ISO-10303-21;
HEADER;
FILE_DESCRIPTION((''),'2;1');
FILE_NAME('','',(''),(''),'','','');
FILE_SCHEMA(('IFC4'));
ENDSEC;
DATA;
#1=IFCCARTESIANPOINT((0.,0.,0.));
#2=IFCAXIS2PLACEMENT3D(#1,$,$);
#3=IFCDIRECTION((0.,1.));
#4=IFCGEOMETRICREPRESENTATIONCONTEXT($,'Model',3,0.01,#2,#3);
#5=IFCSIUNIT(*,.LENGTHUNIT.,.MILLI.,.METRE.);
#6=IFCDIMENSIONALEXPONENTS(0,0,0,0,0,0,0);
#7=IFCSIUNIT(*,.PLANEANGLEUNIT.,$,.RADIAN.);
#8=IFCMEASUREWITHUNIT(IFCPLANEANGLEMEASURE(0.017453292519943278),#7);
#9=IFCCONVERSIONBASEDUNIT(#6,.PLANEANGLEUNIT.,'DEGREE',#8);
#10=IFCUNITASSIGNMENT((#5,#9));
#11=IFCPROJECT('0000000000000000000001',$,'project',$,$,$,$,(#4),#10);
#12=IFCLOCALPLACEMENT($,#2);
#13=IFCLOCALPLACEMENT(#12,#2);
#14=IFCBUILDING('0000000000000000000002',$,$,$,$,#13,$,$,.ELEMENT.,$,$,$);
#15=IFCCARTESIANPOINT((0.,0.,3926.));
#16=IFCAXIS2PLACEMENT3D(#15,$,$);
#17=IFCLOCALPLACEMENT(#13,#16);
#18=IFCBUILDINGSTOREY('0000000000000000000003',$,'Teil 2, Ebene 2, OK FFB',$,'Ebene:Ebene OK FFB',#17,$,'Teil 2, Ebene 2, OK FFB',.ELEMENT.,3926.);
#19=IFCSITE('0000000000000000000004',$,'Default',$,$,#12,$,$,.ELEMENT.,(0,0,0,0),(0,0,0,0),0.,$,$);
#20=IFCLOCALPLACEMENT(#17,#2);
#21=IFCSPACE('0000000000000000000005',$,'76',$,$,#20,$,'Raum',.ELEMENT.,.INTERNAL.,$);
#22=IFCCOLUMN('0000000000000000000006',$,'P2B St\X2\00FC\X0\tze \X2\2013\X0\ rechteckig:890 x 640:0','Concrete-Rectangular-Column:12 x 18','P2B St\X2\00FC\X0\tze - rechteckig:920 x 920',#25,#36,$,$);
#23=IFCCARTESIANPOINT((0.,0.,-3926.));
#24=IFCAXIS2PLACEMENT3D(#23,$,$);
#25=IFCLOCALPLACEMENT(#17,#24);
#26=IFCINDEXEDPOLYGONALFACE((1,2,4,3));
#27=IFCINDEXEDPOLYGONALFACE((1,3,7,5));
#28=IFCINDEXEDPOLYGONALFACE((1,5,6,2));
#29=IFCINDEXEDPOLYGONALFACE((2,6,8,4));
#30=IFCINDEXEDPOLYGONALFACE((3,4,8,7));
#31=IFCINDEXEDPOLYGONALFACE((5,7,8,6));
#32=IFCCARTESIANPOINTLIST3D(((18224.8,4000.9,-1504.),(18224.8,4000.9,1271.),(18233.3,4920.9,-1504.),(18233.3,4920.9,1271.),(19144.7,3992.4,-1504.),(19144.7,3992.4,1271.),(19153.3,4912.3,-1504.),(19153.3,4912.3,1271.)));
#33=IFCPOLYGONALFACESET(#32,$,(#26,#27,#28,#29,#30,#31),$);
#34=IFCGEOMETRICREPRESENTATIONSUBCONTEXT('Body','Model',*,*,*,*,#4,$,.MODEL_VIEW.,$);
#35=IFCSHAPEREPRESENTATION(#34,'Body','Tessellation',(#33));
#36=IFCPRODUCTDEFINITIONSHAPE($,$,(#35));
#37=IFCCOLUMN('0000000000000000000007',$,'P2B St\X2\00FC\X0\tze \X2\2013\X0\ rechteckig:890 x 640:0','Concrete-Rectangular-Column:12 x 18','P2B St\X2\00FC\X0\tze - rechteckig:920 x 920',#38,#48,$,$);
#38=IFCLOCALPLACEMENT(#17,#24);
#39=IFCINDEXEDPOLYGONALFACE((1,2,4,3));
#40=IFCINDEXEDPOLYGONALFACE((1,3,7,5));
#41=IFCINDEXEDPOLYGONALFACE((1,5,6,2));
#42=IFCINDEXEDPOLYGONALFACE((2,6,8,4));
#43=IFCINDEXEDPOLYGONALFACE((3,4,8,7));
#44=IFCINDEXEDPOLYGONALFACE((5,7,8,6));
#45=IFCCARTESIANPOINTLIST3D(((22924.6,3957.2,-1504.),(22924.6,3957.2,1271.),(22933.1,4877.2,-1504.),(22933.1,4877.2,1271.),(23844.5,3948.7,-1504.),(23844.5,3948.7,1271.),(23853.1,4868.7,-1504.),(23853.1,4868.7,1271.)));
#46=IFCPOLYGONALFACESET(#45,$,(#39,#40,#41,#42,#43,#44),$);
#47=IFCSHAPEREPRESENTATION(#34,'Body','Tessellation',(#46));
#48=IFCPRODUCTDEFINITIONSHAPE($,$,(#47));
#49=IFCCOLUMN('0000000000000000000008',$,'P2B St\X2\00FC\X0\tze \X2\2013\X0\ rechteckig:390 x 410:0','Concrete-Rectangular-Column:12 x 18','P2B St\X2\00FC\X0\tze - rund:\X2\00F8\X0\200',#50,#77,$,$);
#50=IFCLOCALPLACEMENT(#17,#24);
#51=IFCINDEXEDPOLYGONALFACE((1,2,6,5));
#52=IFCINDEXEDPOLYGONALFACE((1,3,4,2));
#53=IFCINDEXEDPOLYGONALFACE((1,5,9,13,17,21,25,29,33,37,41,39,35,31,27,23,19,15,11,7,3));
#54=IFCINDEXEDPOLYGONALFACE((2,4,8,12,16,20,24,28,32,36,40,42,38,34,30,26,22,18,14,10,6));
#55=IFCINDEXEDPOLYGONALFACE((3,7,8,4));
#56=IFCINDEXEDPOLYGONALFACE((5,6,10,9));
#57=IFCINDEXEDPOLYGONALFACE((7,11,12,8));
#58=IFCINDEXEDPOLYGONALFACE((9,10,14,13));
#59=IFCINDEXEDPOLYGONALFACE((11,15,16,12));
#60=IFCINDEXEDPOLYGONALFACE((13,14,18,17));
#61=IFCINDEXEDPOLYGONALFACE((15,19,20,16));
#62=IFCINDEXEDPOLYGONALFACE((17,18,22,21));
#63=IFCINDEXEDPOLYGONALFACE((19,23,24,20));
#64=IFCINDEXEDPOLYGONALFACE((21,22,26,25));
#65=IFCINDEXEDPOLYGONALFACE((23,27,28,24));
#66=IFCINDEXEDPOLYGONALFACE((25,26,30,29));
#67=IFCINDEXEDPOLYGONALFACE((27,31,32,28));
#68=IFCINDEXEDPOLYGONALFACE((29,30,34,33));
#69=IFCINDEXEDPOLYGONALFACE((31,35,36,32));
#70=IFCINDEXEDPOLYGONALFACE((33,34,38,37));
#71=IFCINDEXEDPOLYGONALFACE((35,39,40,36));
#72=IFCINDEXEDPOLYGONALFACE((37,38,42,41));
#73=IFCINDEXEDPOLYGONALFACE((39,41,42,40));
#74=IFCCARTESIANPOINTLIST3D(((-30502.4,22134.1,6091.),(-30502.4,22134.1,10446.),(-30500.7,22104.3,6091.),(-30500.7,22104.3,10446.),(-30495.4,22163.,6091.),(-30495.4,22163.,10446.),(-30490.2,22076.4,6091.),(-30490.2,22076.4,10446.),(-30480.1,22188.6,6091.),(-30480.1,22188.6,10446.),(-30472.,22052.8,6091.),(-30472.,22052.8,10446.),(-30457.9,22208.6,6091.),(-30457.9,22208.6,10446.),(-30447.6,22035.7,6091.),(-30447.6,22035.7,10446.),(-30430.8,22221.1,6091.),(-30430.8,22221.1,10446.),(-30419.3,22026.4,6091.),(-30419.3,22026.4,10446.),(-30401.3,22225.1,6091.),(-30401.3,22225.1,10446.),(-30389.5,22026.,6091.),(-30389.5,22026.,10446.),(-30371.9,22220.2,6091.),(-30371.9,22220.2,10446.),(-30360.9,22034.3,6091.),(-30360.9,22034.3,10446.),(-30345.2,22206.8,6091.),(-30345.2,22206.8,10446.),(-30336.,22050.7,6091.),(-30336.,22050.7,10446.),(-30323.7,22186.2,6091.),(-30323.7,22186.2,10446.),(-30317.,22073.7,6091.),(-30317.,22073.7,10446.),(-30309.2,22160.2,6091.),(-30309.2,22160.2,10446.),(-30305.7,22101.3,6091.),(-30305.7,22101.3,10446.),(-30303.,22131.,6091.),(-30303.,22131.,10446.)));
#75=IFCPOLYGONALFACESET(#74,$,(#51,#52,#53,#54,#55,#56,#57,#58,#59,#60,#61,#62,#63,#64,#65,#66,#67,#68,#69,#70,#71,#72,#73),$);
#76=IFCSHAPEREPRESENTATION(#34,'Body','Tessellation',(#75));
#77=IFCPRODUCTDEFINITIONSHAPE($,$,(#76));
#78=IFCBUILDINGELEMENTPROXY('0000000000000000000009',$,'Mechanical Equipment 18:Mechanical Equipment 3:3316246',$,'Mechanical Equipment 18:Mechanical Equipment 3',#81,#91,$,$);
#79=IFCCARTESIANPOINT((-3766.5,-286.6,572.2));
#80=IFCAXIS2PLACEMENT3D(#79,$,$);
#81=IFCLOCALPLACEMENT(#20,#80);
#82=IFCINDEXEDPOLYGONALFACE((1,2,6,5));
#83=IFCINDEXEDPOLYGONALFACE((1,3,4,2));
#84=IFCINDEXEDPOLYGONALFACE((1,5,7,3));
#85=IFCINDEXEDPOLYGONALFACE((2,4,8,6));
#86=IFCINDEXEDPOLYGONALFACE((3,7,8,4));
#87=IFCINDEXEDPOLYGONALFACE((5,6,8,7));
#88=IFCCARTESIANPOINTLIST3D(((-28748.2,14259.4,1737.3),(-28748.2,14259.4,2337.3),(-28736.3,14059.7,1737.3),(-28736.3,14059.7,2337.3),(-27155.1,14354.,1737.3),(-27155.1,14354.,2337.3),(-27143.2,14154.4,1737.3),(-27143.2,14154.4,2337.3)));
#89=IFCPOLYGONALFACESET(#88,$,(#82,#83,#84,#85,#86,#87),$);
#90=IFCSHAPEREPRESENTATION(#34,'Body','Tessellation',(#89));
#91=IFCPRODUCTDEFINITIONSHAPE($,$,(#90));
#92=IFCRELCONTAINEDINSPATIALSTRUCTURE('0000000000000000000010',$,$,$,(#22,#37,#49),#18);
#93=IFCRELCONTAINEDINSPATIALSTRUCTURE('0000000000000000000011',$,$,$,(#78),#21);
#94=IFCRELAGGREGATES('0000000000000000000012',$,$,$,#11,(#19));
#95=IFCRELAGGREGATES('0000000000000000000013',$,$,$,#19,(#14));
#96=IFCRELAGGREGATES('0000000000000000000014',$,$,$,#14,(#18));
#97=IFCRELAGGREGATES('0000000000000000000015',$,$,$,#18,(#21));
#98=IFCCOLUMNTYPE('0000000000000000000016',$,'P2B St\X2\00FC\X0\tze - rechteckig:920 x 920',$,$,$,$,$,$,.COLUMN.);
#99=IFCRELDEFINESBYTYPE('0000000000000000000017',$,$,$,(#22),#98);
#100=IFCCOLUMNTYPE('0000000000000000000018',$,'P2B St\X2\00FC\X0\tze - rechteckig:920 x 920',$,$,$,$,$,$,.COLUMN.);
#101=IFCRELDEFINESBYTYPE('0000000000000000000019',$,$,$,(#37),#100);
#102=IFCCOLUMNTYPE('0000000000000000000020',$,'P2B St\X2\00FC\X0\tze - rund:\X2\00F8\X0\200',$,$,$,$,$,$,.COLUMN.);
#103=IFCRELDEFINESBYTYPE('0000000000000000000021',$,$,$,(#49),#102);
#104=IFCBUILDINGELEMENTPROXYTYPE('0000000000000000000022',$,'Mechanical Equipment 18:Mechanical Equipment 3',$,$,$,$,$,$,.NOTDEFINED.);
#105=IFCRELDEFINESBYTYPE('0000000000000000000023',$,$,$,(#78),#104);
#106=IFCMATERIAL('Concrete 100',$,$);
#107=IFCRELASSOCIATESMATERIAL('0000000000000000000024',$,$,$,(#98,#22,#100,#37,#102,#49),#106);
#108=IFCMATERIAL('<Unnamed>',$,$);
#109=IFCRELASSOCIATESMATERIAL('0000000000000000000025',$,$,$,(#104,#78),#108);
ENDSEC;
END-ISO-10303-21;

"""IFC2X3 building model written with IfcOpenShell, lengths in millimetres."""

from ifc_helpers import new_model, entity, si_unit, converted_unit, direction, frame, frame_2d, origin, origin_2d_with_axis, place, context, subcontext, project, spatial, rectangle, circle, extrude, source, transform, mapped, material, type_object, type_shapes, element, save


model = new_model("IFC2X3")

# Units and contexts
model_context = context("Model", 3, precision=0.01, world=origin(), true_north=direction((0.0, 1.0)))
body_context = subcontext(model_context, "Body", "Model", "MODEL_VIEW")
ifc_project = project(units=[si_unit("LENGTHUNIT", "METRE", prefix="MILLI"), converted_unit("PLANEANGLEUNIT", "DEGREE", entity("IfcPlaneAngleMeasure", 0.017453292519943278), si_unit("PLANEANGLEUNIT", "RADIAN"), dimensions=[0, 0, 0, 0, 0, 0, 0])], contexts=[model_context])

# Site, building, storey
site_placement = place(None, origin())
site = spatial("IfcSite", under=ifc_project, at=site_placement, Name="Default", CompositionType="ELEMENT", RefLatitude=(0, 0, 0, 0), RefLongitude=(0, 0, 0, 0), RefElevation=0.0)
building_placement = place(site_placement, origin())
building = spatial("IfcBuilding", under=site, at=building_placement, CompositionType="ELEMENT")
storey_placement = place(building_placement, frame((0.0, 0.0, 3926.0)))
storey = spatial("IfcBuildingStorey", under=building, at=storey_placement, Name="Teil 2, Ebene 2, OK FFB", ObjectType="Ebene:Ebene OK FFB", LongName="Teil 2, Ebene 2, OK FFB", CompositionType="ELEMENT", Elevation=3926.0)

# Columns
ifc_material_1 = material(Name="Concrete 100")
column_type_1 = type_object("IfcColumnType", Name="P2B Stütze - rechteckig:920 x 920", PredefinedType="COLUMN", material=ifc_material_1)
shared_shape_1 = source(origin(), body_context, "Body", "SweptSolid", [
    extrude(rectangle(XDim=920.0, YDim=920.0, at=frame_2d((3.3, 0.0), x_axis=(1.0, 0.0))), frame((18689.0, 4453.3, -1504.0), z_axis=(0.0, 0.0, 1.0), x_axis=(0.00929, 0.999957, 0.0)), (0.0, 0.0, 1.0), 2775.0),
])
type_shapes(column_type_1, [shared_shape_1])
column_1_placement = place(storey_placement, frame((0.0, 0.0, -3926.0)))
element("IfcColumn", 1, at=column_1_placement, inside=storey, type_object=column_type_1, material=ifc_material_1, Name="P2B Stütze – rechteckig:890 x 640:0", Description="Concrete-Rectangular-Column:12 x 18", ObjectType="P2B Stütze - rechteckig:920 x 920", context=body_context, shape_type="MappedRepresentation", body=[
    mapped(shared_shape_1, transform((0.0, 0.0, 0.0), scale=1.0)),
])
column_type_2 = type_object("IfcColumnType", Name="P2B Stütze - rechteckig:920 x 920", PredefinedType="COLUMN", material=ifc_material_1)
shared_shape_2 = source(origin(), body_context, "Body", "SweptSolid", [
    extrude(rectangle(XDim=920.0, YDim=920.0, at=frame_2d((3.3, 0.0), x_axis=(1.0, 0.0))), frame((23388.8, 4409.6, -1504.0), z_axis=(0.0, 0.0, 1.0), x_axis=(0.00929, 0.999957, 0.0)), (0.0, 0.0, 1.0), 2775.0),
])
type_shapes(column_type_2, [shared_shape_2])
column_2_placement = place(storey_placement, frame((0.0, 0.0, -3926.0)))
element("IfcColumn", 2, at=column_2_placement, inside=storey, type_object=column_type_2, material=ifc_material_1, Name="P2B Stütze – rechteckig:890 x 640:0", Description="Concrete-Rectangular-Column:12 x 18", ObjectType="P2B Stütze - rechteckig:920 x 920", context=body_context, shape_type="MappedRepresentation", body=[
    mapped(shared_shape_2, transform((0.0, 0.0, 0.0), scale=1.0)),
])
column_type_3 = type_object("IfcColumnType", Name="P2B Stütze - rund:ø200", PredefinedType="COLUMN", material=ifc_material_1)
shared_shape_3 = source(origin(), body_context, "Body", "SweptSolid", [
    extrude(circle(Radius=100.0, at=origin_2d_with_axis()), frame((-30402.8, 22125.1, 6091.0), z_axis=(0.0, 0.0, 1.0), x_axis=(0.998239, 0.059319, 0.0)), (0.0, 0.0, 1.0), 4355.0),
])
type_shapes(column_type_3, [shared_shape_3])
column_3_placement = place(storey_placement, frame((0.0, 0.0, -3926.0)))
element("IfcColumn", 3, at=column_3_placement, inside=storey, type_object=column_type_3, material=ifc_material_1, Name="P2B Stütze – rechteckig:390 x 410:0", Description="Concrete-Rectangular-Column:12 x 18", ObjectType="P2B Stütze - rund:ø200", context=body_context, shape_type="MappedRepresentation", body=[
    mapped(shared_shape_3, transform((0.0, 0.0, 0.0), scale=1.0)),
])

# Shared definitions
space_placement = place(storey_placement, origin())
space = spatial("IfcSpace", under=storey, at=space_placement, Name="76", LongName="Raum", CompositionType="ELEMENT", InteriorOrExteriorSpace="INTERNAL")

# Building element proxy
ifc_material_2 = material(Name="<Unnamed>")
building_element_proxy_type = type_object("IfcBuildingElementProxyType", Name="Mechanical Equipment 18:Mechanical Equipment 3", PredefinedType="NOTDEFINED", material=ifc_material_2)
shared_shape_4 = source(origin(), body_context, "Body", "SweptSolid", [
    extrude(rectangle(XDim=200.0, YDim=1595.9, at=origin_2d_with_axis()), frame((-27945.7, 14206.9, 1737.3), z_axis=(0.0, 0.0, 1.0), x_axis=(0.059319, -0.998239, 0.0)), (0.0, 0.0, 1.0), 600.0),
])
type_shapes(building_element_proxy_type, [shared_shape_4])
proxy_placement = place(space_placement, frame((-3766.5, -286.6, 572.2)))
element("IfcBuildingElementProxy", 4, at=proxy_placement, inside=space, type_object=building_element_proxy_type, material=ifc_material_2, Name="Mechanical Equipment 18:Mechanical Equipment 3:3316246", ObjectType="Mechanical Equipment 18:Mechanical Equipment 3", context=body_context, shape_type="MappedRepresentation", body=[
    mapped(shared_shape_4, transform((0.0, 0.0, 0.0), scale=1.0)),
])

save(model, "model.ifc")
